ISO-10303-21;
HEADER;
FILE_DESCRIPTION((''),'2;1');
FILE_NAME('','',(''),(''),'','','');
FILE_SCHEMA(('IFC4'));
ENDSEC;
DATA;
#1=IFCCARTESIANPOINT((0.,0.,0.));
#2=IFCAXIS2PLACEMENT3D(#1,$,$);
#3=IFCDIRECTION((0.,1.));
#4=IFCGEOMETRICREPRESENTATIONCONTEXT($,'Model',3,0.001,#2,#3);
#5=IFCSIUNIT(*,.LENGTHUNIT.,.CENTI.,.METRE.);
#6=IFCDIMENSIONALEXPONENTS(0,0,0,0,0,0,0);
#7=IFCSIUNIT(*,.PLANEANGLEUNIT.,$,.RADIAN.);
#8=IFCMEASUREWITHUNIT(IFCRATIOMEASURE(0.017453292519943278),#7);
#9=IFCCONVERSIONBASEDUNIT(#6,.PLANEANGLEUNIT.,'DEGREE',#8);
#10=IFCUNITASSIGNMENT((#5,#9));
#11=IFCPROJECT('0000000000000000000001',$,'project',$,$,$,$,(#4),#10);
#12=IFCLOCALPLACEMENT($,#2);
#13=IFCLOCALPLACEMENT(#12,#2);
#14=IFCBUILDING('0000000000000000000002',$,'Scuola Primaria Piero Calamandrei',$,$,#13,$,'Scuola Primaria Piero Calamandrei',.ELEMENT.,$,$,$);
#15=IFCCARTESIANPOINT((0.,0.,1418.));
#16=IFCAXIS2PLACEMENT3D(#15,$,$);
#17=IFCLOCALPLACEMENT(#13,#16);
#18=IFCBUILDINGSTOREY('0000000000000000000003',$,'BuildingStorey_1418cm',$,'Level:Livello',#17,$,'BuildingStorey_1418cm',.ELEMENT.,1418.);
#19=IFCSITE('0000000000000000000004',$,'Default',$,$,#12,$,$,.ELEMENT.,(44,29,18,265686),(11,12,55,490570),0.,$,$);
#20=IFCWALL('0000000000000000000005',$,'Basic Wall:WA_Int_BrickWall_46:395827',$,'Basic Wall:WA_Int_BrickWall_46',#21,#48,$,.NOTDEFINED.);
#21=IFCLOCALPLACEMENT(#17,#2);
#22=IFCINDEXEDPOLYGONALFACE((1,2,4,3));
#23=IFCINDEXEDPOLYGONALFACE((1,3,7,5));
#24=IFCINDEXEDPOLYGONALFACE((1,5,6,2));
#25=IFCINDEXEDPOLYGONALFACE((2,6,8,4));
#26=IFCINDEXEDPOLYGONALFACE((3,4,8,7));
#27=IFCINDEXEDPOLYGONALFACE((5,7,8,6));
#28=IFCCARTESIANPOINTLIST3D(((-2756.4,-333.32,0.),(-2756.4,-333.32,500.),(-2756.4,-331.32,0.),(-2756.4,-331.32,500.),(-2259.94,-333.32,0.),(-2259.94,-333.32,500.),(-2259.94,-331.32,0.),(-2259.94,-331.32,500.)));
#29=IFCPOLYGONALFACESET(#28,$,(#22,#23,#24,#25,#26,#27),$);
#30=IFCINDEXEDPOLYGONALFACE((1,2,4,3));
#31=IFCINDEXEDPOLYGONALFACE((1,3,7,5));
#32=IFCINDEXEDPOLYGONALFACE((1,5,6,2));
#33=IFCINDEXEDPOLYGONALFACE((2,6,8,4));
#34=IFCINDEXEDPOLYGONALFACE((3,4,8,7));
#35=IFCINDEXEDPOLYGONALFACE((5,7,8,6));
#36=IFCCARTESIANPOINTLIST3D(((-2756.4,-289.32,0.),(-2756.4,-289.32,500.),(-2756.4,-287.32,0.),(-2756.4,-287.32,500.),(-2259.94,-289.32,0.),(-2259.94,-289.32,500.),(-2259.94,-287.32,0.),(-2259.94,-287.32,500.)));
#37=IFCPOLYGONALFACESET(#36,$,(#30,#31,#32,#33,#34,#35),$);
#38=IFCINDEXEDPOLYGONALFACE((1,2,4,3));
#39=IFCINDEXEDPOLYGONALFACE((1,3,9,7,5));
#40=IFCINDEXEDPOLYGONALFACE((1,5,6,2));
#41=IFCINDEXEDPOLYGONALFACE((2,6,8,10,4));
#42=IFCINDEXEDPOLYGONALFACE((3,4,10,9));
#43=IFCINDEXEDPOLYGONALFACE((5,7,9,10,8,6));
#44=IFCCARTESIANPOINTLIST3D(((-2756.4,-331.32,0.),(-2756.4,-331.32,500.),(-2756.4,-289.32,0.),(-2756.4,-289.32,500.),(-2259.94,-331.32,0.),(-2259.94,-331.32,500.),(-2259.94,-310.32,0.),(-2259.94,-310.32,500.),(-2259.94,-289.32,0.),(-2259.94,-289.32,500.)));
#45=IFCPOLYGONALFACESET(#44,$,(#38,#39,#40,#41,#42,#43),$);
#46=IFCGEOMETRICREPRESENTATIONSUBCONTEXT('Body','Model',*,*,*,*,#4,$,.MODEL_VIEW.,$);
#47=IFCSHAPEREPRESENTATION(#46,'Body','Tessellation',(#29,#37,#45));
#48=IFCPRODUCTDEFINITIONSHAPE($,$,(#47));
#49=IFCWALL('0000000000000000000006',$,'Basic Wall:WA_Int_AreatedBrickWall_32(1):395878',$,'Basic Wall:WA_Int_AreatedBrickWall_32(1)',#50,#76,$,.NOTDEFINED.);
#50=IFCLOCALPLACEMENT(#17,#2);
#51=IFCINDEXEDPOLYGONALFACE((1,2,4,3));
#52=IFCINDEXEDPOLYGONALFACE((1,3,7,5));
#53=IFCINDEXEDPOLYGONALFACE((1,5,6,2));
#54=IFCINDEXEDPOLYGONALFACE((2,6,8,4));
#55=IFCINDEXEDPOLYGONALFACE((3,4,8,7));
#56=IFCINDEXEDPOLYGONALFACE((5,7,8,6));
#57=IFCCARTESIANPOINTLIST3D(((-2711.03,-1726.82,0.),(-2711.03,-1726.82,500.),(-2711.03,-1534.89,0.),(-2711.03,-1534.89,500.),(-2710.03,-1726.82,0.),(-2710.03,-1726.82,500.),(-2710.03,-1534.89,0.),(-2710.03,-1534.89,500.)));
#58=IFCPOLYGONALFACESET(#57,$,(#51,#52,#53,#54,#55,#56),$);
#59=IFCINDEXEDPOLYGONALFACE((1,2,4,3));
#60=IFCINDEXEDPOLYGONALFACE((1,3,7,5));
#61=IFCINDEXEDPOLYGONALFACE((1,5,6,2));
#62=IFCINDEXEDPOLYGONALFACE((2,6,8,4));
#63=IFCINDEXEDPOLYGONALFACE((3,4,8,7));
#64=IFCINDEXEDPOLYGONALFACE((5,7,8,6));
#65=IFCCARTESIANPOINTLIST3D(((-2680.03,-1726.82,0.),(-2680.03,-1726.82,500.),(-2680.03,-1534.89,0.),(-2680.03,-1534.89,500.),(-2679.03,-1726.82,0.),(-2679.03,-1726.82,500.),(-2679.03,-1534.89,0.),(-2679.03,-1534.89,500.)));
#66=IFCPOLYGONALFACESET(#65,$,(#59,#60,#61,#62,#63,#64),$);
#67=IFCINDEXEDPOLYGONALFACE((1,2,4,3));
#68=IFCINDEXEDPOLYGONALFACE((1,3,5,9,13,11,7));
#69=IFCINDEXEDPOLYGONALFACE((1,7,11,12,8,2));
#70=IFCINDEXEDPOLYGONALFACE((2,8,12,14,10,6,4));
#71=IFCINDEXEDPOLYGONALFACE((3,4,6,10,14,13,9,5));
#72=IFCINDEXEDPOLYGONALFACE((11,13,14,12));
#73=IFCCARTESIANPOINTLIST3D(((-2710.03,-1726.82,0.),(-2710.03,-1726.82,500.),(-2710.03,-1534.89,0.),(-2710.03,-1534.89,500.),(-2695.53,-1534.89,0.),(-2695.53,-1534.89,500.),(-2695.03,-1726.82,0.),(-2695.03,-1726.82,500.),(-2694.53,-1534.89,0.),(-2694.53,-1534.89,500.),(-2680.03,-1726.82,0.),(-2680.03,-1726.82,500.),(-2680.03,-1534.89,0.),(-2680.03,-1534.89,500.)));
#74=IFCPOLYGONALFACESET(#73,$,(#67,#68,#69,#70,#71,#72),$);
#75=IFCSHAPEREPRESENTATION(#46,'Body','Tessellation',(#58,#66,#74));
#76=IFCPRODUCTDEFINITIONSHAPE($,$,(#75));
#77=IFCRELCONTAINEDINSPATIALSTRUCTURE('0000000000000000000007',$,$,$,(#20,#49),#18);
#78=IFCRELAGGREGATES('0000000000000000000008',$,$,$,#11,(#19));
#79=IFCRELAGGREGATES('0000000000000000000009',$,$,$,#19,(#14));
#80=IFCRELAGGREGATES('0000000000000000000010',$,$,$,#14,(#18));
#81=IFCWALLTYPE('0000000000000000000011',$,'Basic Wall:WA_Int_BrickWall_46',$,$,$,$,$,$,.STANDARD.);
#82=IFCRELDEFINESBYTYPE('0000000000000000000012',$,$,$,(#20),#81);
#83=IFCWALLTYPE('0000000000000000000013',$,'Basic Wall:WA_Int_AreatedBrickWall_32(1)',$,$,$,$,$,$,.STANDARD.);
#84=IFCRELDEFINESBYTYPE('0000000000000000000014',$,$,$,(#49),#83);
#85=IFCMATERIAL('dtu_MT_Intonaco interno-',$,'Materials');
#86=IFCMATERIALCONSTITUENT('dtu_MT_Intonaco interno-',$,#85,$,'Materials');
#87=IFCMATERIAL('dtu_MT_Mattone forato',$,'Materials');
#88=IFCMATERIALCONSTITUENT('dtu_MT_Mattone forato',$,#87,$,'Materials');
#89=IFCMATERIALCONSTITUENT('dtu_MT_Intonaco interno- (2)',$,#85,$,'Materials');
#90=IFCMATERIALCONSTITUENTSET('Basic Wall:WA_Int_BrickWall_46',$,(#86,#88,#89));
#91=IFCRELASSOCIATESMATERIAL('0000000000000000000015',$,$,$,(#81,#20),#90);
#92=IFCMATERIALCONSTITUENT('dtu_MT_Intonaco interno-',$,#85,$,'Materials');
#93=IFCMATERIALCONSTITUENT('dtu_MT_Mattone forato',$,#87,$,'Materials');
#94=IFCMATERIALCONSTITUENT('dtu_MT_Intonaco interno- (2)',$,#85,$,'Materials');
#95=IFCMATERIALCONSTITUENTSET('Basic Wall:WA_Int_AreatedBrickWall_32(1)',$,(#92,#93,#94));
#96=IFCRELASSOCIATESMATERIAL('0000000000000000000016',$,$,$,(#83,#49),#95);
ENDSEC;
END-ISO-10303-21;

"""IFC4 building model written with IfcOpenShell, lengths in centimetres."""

from ifc_helpers import new_model, entity, si_unit, converted_unit, direction, frame, origin, place, context, subcontext, project, spatial, indexed_curve, outline, extrude, material, constituent, constituent_set, type_object, element, save


model = new_model("IFC4")

# Units and contexts
model_context = context("Model", 3, precision=0.001, world=origin(), true_north=direction((0.0, 1.0)))
body_context = subcontext(model_context, "Body", "Model", "MODEL_VIEW")
ifc_project = project(units=[si_unit("LENGTHUNIT", "METRE", prefix="CENTI"), converted_unit("PLANEANGLEUNIT", "DEGREE", entity("IfcRatioMeasure", 0.017453292519943278), si_unit("PLANEANGLEUNIT", "RADIAN"), dimensions=[0, 0, 0, 0, 0, 0, 0])], contexts=[model_context])

# Site, building, storey
site_placement = place(None, origin())
site = spatial("IfcSite", under=ifc_project, at=site_placement, Name="Default", CompositionType="ELEMENT", RefLatitude=(44, 29, 18, 265686), RefLongitude=(11, 12, 55, 490570), RefElevation=0.0)
building_placement = place(site_placement, origin())
building = spatial("IfcBuilding", under=site, at=building_placement, Name="Scuola Primaria Piero Calamandrei", LongName="Scuola Primaria Piero Calamandrei", CompositionType="ELEMENT")
storey_placement = place(building_placement, frame((0.0, 0.0, 1418.0)))
storey = spatial("IfcBuildingStorey", under=building, at=storey_placement, Name="BuildingStorey_1418cm", ObjectType="Level:Livello", LongName="BuildingStorey_1418cm", CompositionType="ELEMENT", Elevation=1418.0)

# Shared definitions
ifc_material_1 = material(Name="dtu_MT_Intonaco interno-", Category="Materials")

# Shared definitions
ifc_constituent_1 = constituent(ifc_material_1, Name="dtu_MT_Intonaco interno-", Category="Materials")
ifc_material_2 = material(Name="dtu_MT_Mattone forato", Category="Materials")
ifc_constituent_2 = constituent(ifc_material_2, Name="dtu_MT_Mattone forato", Category="Materials")
ifc_constituent_3 = constituent(ifc_material_1, Name="dtu_MT_Intonaco interno- (2)", Category="Materials")
ifc_constituent_set_1 = constituent_set(constituents=[ifc_constituent_1, ifc_constituent_2, ifc_constituent_3], Name="Basic Wall:WA_Int_BrickWall_46")
wall_type_1 = type_object("IfcWallType", Name="Basic Wall:WA_Int_BrickWall_46", PredefinedType="STANDARD", material=ifc_constituent_set_1)

# Wall
wall_1_placement = place(storey_placement, frame((-2756.4, -310.32, 0.0)))
element("IfcWall", 1, at=wall_1_placement, inside=storey, type_object=wall_type_1, material=ifc_constituent_set_1, Name="Basic Wall:WA_Int_BrickWall_46:395827", ObjectType="Basic Wall:WA_Int_BrickWall_46", PredefinedType="NOTDEFINED", context=body_context, shape_type="SweptSolid", body=[
    extrude(outline(indexed_curve([(-1.0, -248.23), (1.0, -248.23), (1.0, 248.23), (-1.0, 248.23), (-1.0, -248.23)], self_intersect=False)), frame((248.23, -22.0, 0.0), z_axis=(0.0, 0.0, 1.0), x_axis=(0.0, 1.0, 0.0)), (0.0, 0.0, 1.0), 500.0),
    extrude(outline(indexed_curve([(-1.0, -248.23), (1.0, -248.23), (1.0, 248.23), (-1.0, 248.23), (-1.0, -248.23)], self_intersect=False)), frame((248.23, 22.0, 0.0), z_axis=(0.0, 0.0, 1.0), x_axis=(0.0, -1.0, 0.0)), (0.0, 0.0, 1.0), 500.0),
    extrude(outline(indexed_curve([(-297.88, -21.0), (198.59, -21.0), (198.59, 0.0), (198.59, 21.0), (-297.88, 21.0), (-297.88, -21.0)], self_intersect=False)), frame((297.88, 0.0, 0.0)), (0.0, 0.0, 1.0), 500.0),
])

# Shared definitions
ifc_constituent_4 = constituent(ifc_material_1, Name="dtu_MT_Intonaco interno-", Category="Materials")
ifc_constituent_5 = constituent(ifc_material_2, Name="dtu_MT_Mattone forato", Category="Materials")
ifc_constituent_6 = constituent(ifc_material_1, Name="dtu_MT_Intonaco interno- (2)", Category="Materials")
ifc_constituent_set_2 = constituent_set(constituents=[ifc_constituent_4, ifc_constituent_5, ifc_constituent_6], Name="Basic Wall:WA_Int_AreatedBrickWall_32(1)")
wall_type_2 = type_object("IfcWallType", Name="Basic Wall:WA_Int_AreatedBrickWall_32(1)", PredefinedType="STANDARD", material=ifc_constituent_set_2)

# Wall
wall_2_placement = place(storey_placement, frame((-2695.03, -1534.89, 0.0), z_axis=(0.0, 0.0, 1.0), x_axis=(0.0, -1.0, 0.0)))
element("IfcWall", 2, at=wall_2_placement, inside=storey, type_object=wall_type_2, material=ifc_constituent_set_2, Name="Basic Wall:WA_Int_AreatedBrickWall_32(1):395878", ObjectType="Basic Wall:WA_Int_AreatedBrickWall_32(1)", PredefinedType="NOTDEFINED", context=body_context, shape_type="SweptSolid", body=[
    extrude(outline(indexed_curve([(-0.5, -95.96), (0.5, -95.96), (0.5, 95.96), (-0.5, 95.96), (-0.5, -95.96)], self_intersect=False)), frame((95.96, -15.5, 0.0), z_axis=(0.0, 0.0, 1.0), x_axis=(0.0, 1.0, 0.0)), (0.0, 0.0, 1.0), 500.0),
    extrude(outline(indexed_curve([(-0.5, -95.96), (0.5, -95.96), (0.5, 95.96), (-0.5, 95.96), (-0.5, -95.96)], self_intersect=False)), frame((95.96, 15.5, 0.0), z_axis=(0.0, 0.0, 1.0), x_axis=(0.0, -1.0, 0.0)), (0.0, 0.0, 1.0), 500.0),
    extrude(outline(indexed_curve([(0.5, -82.25), (15.0, -82.25), (15.0, 109.67), (0.0, 109.67), (-15.0, 109.67), (-15.0, -82.25), (-0.5, -82.25), (0.5, -82.25)], self_intersect=False)), frame((82.25, 0.0, 0.0), z_axis=(0.0, 0.0, 1.0), x_axis=(0.0, -1.0, 0.0)), (0.0, 0.0, 1.0), 500.0),
])

save(model, "model.ifc")
